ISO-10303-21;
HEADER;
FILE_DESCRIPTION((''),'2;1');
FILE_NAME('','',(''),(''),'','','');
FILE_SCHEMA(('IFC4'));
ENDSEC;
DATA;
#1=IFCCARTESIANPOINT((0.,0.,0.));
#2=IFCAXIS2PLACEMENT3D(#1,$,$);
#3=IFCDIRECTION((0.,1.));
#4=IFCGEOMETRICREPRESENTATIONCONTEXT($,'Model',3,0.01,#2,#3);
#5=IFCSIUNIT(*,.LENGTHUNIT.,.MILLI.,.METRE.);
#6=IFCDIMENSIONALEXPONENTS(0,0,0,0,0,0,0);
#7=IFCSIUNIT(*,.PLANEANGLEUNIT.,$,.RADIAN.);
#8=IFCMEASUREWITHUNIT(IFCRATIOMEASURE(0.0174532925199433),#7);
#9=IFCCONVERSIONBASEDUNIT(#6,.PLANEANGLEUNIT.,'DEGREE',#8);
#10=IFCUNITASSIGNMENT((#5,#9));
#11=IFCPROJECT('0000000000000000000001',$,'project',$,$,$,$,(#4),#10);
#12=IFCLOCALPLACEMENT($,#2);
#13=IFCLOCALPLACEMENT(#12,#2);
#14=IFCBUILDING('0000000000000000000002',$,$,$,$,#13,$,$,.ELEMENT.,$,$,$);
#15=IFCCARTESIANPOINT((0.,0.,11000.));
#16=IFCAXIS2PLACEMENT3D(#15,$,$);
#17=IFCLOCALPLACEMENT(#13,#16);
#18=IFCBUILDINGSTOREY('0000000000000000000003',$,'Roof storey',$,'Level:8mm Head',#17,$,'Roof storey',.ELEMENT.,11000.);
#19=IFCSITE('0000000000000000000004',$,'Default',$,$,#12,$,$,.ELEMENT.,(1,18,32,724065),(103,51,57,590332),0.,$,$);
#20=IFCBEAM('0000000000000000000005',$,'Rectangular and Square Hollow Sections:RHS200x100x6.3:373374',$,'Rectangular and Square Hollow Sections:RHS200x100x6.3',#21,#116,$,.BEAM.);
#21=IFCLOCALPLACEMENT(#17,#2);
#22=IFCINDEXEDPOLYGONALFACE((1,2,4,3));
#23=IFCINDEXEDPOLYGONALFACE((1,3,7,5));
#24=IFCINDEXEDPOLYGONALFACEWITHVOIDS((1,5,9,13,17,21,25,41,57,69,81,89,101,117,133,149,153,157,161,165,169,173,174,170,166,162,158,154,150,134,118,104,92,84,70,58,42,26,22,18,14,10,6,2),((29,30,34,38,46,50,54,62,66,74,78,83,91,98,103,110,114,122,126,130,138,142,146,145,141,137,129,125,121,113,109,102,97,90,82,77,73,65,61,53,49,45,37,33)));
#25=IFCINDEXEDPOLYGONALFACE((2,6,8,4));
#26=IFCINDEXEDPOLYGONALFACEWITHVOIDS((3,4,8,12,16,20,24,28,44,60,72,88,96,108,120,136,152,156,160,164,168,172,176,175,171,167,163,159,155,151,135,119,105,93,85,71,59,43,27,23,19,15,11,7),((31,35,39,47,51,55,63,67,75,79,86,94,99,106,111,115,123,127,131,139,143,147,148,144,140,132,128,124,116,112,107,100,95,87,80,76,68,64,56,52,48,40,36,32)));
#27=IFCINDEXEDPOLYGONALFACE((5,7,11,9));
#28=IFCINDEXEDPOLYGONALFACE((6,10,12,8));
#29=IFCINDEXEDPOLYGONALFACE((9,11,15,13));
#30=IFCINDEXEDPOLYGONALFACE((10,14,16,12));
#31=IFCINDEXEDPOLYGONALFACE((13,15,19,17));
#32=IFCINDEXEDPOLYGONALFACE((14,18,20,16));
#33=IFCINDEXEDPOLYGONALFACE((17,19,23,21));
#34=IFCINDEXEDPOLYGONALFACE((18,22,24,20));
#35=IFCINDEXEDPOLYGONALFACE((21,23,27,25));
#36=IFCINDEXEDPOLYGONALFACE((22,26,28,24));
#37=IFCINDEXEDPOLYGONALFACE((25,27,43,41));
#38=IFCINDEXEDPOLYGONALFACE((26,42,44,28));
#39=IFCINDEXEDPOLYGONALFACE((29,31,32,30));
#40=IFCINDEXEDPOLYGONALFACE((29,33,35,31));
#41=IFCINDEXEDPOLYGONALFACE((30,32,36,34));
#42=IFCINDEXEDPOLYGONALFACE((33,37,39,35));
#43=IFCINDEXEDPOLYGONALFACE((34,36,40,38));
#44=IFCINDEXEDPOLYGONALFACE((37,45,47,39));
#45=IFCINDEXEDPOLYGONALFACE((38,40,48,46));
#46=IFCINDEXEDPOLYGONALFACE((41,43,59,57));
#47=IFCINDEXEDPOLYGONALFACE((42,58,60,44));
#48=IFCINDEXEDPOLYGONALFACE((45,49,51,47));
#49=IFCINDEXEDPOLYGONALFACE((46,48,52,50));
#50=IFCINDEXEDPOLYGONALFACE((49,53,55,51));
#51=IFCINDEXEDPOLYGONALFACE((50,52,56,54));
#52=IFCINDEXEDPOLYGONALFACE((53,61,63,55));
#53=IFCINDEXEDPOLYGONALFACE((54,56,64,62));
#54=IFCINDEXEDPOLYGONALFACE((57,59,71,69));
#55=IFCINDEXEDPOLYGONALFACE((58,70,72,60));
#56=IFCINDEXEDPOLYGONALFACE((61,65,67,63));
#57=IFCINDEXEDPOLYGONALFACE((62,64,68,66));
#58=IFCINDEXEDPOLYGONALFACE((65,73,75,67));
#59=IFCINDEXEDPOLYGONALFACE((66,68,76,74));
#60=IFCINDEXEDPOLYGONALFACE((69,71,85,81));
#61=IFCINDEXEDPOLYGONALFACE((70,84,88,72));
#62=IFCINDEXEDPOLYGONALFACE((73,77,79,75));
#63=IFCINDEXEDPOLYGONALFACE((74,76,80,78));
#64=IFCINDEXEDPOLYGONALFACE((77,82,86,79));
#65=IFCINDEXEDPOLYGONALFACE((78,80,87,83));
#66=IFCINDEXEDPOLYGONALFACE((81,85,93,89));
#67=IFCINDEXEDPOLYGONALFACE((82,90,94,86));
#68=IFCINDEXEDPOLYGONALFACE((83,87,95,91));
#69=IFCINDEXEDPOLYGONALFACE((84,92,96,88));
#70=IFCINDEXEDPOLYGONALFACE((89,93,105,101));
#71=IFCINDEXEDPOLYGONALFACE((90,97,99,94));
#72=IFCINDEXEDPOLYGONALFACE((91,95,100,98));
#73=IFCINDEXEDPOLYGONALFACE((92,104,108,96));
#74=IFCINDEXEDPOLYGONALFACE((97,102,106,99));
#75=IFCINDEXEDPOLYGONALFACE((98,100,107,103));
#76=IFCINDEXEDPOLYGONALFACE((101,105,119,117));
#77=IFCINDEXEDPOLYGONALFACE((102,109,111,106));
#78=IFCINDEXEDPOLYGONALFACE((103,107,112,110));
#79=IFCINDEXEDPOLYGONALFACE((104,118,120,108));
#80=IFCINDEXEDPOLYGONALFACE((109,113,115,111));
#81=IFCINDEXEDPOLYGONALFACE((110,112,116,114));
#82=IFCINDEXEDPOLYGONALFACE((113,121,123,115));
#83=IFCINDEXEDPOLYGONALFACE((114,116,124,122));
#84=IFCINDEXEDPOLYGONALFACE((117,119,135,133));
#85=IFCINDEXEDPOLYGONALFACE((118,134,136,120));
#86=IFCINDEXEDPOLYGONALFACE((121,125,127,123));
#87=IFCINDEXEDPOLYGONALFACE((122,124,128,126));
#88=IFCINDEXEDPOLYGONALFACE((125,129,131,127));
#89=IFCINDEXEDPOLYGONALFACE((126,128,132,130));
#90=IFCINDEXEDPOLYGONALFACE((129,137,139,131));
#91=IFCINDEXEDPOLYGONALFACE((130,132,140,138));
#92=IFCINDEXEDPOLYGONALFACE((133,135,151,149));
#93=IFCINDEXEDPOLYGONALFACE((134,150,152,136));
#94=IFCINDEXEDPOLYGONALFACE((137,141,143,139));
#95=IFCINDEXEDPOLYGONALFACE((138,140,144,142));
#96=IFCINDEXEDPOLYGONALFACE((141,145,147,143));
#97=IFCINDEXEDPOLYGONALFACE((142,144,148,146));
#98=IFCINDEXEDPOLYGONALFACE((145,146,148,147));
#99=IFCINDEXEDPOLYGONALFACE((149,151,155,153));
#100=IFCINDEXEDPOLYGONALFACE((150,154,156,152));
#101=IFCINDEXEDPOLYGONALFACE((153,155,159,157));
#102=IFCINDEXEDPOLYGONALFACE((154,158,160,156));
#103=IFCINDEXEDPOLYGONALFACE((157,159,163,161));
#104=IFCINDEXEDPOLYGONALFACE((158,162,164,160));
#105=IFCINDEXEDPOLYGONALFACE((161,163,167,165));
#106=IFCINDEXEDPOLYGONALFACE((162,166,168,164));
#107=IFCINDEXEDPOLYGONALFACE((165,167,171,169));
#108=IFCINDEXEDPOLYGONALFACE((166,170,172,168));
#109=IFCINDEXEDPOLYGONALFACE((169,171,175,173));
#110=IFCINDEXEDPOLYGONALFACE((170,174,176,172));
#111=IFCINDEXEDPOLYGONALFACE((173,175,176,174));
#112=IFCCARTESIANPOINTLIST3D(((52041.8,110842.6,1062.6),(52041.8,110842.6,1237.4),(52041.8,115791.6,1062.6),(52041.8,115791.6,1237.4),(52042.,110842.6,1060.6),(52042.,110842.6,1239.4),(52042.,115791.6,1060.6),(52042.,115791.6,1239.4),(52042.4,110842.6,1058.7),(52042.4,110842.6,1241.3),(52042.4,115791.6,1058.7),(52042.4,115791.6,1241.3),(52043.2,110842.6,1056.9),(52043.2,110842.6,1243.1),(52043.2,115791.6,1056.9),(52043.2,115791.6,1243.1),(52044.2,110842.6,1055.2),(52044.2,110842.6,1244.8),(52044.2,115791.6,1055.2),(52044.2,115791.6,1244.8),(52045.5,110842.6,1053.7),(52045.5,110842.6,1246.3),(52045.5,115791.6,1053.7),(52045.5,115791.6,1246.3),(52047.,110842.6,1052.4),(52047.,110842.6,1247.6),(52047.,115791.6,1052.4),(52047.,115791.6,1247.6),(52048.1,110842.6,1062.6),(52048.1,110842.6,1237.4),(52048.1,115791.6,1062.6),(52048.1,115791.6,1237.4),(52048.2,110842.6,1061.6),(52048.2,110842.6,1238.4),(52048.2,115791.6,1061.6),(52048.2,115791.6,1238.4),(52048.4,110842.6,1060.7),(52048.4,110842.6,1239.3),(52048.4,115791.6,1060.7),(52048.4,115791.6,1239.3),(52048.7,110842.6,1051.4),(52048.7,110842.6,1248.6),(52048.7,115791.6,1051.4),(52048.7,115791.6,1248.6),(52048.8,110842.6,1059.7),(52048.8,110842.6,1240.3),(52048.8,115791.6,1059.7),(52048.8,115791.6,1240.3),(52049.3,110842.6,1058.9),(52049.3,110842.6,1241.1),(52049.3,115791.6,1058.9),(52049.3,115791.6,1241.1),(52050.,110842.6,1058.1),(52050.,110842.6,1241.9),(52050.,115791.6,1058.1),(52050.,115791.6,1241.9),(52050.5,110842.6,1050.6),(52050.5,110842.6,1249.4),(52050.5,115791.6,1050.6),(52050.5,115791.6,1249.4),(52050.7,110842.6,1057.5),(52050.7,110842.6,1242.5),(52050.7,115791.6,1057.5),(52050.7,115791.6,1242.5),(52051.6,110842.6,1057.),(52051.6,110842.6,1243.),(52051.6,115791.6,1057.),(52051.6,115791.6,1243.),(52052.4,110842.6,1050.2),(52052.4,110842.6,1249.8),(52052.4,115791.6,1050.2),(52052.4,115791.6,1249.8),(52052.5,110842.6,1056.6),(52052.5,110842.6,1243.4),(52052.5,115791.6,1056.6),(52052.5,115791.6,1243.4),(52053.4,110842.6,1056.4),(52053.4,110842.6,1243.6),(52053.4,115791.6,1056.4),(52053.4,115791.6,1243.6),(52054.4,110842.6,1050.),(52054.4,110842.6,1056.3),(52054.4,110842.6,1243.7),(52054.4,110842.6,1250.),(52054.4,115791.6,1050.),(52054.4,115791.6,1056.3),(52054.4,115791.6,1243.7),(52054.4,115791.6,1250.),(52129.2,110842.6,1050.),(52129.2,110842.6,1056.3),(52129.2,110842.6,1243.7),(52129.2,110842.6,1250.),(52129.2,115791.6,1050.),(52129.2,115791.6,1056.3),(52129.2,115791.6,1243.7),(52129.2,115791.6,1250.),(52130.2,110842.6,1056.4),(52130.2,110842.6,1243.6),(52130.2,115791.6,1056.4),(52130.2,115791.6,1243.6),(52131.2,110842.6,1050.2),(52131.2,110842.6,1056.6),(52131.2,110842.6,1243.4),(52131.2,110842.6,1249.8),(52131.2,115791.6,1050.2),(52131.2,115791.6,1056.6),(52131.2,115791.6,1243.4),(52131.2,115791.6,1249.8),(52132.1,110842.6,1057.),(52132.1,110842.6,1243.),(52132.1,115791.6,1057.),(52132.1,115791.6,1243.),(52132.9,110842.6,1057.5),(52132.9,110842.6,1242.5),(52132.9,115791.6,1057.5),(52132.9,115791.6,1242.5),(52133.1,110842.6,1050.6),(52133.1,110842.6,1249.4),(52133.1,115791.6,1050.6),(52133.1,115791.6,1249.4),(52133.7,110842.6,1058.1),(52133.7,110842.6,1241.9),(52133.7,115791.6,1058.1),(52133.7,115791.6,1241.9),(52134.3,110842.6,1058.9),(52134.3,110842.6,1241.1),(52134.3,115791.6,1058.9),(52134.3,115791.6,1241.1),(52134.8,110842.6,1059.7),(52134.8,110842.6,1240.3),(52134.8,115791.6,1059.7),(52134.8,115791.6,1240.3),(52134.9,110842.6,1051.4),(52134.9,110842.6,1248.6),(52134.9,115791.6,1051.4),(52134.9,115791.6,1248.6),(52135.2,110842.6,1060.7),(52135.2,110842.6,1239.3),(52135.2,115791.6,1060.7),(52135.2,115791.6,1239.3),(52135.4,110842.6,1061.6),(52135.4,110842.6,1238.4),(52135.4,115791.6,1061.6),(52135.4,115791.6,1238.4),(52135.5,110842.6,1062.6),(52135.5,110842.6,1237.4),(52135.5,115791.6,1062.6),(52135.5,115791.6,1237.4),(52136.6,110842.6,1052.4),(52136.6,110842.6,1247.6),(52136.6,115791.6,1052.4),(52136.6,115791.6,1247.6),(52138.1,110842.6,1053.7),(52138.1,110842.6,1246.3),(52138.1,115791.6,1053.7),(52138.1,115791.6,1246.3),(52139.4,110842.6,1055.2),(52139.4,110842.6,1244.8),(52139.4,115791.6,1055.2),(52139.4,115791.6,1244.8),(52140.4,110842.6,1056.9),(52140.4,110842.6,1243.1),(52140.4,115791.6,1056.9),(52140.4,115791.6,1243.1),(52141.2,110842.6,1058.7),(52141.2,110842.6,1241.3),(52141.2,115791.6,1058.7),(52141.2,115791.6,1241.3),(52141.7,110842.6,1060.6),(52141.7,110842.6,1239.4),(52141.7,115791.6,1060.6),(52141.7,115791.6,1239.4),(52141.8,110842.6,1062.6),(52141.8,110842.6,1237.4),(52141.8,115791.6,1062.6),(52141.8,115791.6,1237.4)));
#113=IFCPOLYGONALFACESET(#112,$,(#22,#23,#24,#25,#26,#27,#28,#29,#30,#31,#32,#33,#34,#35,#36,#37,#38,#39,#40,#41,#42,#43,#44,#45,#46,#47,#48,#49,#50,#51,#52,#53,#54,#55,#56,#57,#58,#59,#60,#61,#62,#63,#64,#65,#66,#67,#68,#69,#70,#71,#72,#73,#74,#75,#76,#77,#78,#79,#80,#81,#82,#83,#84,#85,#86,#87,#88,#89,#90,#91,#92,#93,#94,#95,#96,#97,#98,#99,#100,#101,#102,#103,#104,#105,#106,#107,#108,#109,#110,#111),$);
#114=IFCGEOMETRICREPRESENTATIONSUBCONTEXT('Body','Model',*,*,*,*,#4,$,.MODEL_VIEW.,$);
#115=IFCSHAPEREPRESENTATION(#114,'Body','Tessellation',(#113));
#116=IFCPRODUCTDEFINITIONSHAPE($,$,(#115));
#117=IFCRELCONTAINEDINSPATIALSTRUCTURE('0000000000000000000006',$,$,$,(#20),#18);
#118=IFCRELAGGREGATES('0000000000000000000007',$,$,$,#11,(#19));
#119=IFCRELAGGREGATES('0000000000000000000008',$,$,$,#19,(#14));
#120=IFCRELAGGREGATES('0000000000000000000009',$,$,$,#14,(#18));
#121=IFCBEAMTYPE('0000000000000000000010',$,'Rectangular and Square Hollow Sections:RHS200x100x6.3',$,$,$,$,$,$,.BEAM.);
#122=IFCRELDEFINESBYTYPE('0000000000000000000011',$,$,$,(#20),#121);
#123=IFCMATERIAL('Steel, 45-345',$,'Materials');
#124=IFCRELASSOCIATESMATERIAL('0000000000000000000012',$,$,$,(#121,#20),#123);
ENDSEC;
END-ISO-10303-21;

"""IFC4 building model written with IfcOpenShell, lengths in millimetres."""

from ifc_helpers import new_model, entity, si_unit, converted_unit, direction, frame, origin, place, context, subcontext, project, spatial, indexed_curve, outline, extrude, source, transform, mapped, material, type_object, type_shapes, element, save


model = new_model("IFC4")

# Units and contexts
model_context = context("Model", 3, precision=0.01, world=origin(), true_north=direction((0.0, 1.0)))
body_context = subcontext(model_context, "Body", "Model", "MODEL_VIEW")
ifc_project = project(units=[si_unit("LENGTHUNIT", "METRE", prefix="MILLI"), converted_unit("PLANEANGLEUNIT", "DEGREE", entity("IfcRatioMeasure", 0.0174532925199433), si_unit("PLANEANGLEUNIT", "RADIAN"), dimensions=[0, 0, 0, 0, 0, 0, 0])], contexts=[model_context])

# Site, building, storey
site_placement = place(None, origin())
site = spatial("IfcSite", under=ifc_project, at=site_placement, Name="Default", CompositionType="ELEMENT", RefLatitude=(1, 18, 32, 724065), RefLongitude=(103, 51, 57, 590332), RefElevation=0.0)
building_placement = place(site_placement, origin())
building = spatial("IfcBuilding", under=site, at=building_placement, CompositionType="ELEMENT")
storey_placement = place(building_placement, frame((0.0, 0.0, 11000.0)))
storey = spatial("IfcBuildingStorey", under=building, at=storey_placement, Name="Roof storey", ObjectType="Level:8mm Head", LongName="Roof storey", CompositionType="ELEMENT", Elevation=11000.0)

# Shared definitions
ifc_material = material(Name="Steel, 45-345", Category="Materials")

# Beam
beam_type_1 = type_object("IfcBeamType", Name="Rectangular and Square Hollow Sections:RHS200x100x6.3", PredefinedType="BEAM", material=ifc_material)
shared_shape_1 = source(origin(), body_context, "Body", "SweptSolid", [
    extrude(outline(indexed_curve([(87.4, -50.0), (89.4, -49.8), (91.3, -49.4), (93.1, -48.6), (94.8, -47.6), (96.3, -46.3), (97.6, -44.8), (98.6, -43.1), (99.4, -41.3), (99.8, -39.4), (100.0, -37.4), (100.0, 37.4), (99.8, 39.4), (99.4, 41.3), (98.6, 43.1), (97.6, 44.8), (96.3, 46.3), (94.8, 47.6), (93.1, 48.6), (91.3, 49.4), (89.4, 49.8), (87.4, 50.0), (-87.4, 50.0), (-89.4, 49.8), (-91.3, 49.4), (-93.1, 48.6), (-94.8, 47.6), (-96.3, 46.3), (-97.6, 44.8), (-98.6, 43.1), (-99.4, 41.3), (-99.8, 39.4), (-100.0, 37.4), (-100.0, -37.4), (-99.8, -39.4), (-99.4, -41.3), (-98.6, -43.1), (-97.6, -44.8), (-96.3, -46.3), (-94.8, -47.6), (-93.1, -48.6), (-91.3, -49.4), (-89.4, -49.8), (-87.4, -50.0), (87.4, -50.0)], self_intersect=False), holes=[indexed_curve([(93.7, 37.4), (93.7, -37.4), (93.6, -38.4), (93.4, -39.3), (93.0, -40.3), (92.5, -41.1), (91.9, -41.9), (91.1, -42.5), (90.3, -43.0), (89.3, -43.4), (88.4, -43.6), (87.4, -43.7), (-87.4, -43.7), (-88.4, -43.6), (-89.3, -43.4), (-90.3, -43.0), (-91.1, -42.5), (-91.9, -41.9), (-92.5, -41.1), (-93.0, -40.3), (-93.4, -39.3), (-93.6, -38.4), (-93.7, -37.4), (-93.7, 37.4), (-93.6, 38.4), (-93.4, 39.3), (-93.0, 40.3), (-92.5, 41.1), (-91.9, 41.9), (-91.1, 42.5), (-90.3, 43.0), (-89.3, 43.4), (-88.4, 43.6), (-87.4, 43.7), (87.4, 43.7), (88.4, 43.6), (89.3, 43.4), (90.3, 43.0), (91.1, 42.5), (91.9, 41.9), (92.5, 41.1), (93.0, 40.3), (93.4, 39.3), (93.6, 38.4), (93.7, 37.4)], self_intersect=False)]), frame((-2474.5, 0.0, 0.0), z_axis=(1.0, 0.0, 0.0), x_axis=(0.0, 0.0, 1.0)), (0.0, 0.0, 1.0), 4949.0),
])
type_shapes(beam_type_1, [shared_shape_1])
for number, where, z_axis, x_axis, name in (
    (1, (52091.8, 113317.1, 1150.0), (0.0, 0.0, 1.0), (0.0, 1.0, 0.0), "Rectangular and Square Hollow Sections:RHS200x100x6.3:373374"),
):
    element("IfcBeam", number, at=place(storey_placement, frame(where, z_axis=z_axis, x_axis=x_axis)), inside=storey, type_object=beam_type_1, material=ifc_material, Name=name, ObjectType="Rectangular and Square Hollow Sections:RHS200x100x6.3", PredefinedType="BEAM", context=body_context, shape_type="MappedRepresentation", body=[
        mapped(shared_shape_1, transform((0.0, 0.0, 0.0), scale=1.0)),
    ])

save(model, "model.ifc")
